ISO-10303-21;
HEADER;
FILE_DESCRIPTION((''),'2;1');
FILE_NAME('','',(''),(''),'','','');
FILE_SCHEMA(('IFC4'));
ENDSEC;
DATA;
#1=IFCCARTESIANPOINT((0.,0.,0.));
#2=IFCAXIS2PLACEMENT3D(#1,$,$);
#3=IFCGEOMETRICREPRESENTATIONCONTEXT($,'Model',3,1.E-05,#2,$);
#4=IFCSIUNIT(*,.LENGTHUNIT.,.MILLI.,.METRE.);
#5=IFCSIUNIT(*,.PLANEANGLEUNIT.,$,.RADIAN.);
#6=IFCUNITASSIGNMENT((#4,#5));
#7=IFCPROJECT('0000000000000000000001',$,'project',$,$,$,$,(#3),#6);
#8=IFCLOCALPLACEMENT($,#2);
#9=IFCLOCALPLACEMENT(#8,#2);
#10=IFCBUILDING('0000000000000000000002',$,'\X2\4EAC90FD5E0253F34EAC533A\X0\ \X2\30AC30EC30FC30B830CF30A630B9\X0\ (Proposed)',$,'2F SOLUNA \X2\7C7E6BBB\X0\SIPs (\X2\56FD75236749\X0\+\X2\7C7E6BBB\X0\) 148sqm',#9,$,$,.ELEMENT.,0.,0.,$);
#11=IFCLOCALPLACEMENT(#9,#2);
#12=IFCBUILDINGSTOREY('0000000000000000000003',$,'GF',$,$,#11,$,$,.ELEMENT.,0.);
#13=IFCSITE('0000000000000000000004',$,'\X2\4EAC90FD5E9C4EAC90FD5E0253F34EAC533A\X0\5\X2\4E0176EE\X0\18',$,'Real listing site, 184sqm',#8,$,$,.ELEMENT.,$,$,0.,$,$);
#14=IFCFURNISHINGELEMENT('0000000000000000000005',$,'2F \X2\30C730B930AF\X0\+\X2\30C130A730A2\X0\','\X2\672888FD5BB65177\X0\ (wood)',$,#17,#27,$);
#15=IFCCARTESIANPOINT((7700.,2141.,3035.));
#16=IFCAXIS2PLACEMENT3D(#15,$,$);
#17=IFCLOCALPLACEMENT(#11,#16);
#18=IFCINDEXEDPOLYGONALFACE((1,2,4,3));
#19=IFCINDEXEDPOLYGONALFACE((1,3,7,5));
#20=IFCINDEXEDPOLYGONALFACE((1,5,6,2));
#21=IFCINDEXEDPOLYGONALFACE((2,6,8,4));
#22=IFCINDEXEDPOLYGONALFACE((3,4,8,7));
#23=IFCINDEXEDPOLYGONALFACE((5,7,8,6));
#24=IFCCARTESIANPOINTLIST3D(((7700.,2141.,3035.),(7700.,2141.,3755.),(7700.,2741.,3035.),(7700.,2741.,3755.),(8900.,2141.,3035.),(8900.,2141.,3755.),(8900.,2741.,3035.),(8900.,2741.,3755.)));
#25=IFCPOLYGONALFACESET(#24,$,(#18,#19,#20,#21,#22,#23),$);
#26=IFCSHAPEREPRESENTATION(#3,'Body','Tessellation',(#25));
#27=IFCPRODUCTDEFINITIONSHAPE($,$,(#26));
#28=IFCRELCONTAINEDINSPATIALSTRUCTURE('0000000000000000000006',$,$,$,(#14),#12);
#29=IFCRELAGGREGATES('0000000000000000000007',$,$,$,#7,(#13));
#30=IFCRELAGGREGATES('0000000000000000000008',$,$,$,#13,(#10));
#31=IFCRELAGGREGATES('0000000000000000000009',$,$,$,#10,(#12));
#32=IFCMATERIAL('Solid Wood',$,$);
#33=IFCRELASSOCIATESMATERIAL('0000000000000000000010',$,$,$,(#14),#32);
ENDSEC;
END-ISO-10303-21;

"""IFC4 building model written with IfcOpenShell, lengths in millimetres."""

from ifc_helpers import new_model, si_unit, frame, frame_2d, origin, place, context, project, spatial, rectangle, extrude, material, element, save


model = new_model("IFC4")

# Units and contexts
model_context = context("Model", 3, precision=1e-05, world=origin())
ifc_project = project(units=[si_unit("LENGTHUNIT", "METRE", prefix="MILLI"), si_unit("PLANEANGLEUNIT", "RADIAN")], contexts=[model_context])

# Site, building, storey
site_placement = place(None, origin())
site = spatial("IfcSite", under=ifc_project, at=site_placement, Name="京都府京都市右京区5丁目18", ObjectType="Real listing site, 184sqm", CompositionType="ELEMENT", RefElevation=0.0)
building_placement = place(site_placement, origin())
building = spatial("IfcBuilding", under=site, at=building_placement, Name="京都市右京区 ガレージハウス (Proposed)", ObjectType="2F SOLUNA 籾殻SIPs (国産杉+籾殻) 148sqm", CompositionType="ELEMENT", ElevationOfRefHeight=0.0, ElevationOfTerrain=0.0)
storey_placement = place(building_placement, origin())
storey = spatial("IfcBuildingStorey", under=building, at=storey_placement, Name="GF", CompositionType="ELEMENT", Elevation=0.0)

# Shared definitions
ifc_material_1 = material(Name="Solid Wood")

# Furnishing element
furnishing_1_placement = place(storey_placement, frame((7700.0, 2141.0, 3035.0)))
element("IfcFurnishingElement", 1, at=furnishing_1_placement, inside=storey, material=ifc_material_1, Name="2F デスク+チェア", Description="木製家具 (wood)", context=model_context, shape_type="SweptSolid", body=[
    extrude(rectangle(XDim=1200.0, YDim=600.0, at=frame_2d((600.0, 300.0))), frame((7700.0, 2141.0, 3035.0)), (0.0, 0.0, 1.0), 720.0),
])

save(model, "model.ifc")
